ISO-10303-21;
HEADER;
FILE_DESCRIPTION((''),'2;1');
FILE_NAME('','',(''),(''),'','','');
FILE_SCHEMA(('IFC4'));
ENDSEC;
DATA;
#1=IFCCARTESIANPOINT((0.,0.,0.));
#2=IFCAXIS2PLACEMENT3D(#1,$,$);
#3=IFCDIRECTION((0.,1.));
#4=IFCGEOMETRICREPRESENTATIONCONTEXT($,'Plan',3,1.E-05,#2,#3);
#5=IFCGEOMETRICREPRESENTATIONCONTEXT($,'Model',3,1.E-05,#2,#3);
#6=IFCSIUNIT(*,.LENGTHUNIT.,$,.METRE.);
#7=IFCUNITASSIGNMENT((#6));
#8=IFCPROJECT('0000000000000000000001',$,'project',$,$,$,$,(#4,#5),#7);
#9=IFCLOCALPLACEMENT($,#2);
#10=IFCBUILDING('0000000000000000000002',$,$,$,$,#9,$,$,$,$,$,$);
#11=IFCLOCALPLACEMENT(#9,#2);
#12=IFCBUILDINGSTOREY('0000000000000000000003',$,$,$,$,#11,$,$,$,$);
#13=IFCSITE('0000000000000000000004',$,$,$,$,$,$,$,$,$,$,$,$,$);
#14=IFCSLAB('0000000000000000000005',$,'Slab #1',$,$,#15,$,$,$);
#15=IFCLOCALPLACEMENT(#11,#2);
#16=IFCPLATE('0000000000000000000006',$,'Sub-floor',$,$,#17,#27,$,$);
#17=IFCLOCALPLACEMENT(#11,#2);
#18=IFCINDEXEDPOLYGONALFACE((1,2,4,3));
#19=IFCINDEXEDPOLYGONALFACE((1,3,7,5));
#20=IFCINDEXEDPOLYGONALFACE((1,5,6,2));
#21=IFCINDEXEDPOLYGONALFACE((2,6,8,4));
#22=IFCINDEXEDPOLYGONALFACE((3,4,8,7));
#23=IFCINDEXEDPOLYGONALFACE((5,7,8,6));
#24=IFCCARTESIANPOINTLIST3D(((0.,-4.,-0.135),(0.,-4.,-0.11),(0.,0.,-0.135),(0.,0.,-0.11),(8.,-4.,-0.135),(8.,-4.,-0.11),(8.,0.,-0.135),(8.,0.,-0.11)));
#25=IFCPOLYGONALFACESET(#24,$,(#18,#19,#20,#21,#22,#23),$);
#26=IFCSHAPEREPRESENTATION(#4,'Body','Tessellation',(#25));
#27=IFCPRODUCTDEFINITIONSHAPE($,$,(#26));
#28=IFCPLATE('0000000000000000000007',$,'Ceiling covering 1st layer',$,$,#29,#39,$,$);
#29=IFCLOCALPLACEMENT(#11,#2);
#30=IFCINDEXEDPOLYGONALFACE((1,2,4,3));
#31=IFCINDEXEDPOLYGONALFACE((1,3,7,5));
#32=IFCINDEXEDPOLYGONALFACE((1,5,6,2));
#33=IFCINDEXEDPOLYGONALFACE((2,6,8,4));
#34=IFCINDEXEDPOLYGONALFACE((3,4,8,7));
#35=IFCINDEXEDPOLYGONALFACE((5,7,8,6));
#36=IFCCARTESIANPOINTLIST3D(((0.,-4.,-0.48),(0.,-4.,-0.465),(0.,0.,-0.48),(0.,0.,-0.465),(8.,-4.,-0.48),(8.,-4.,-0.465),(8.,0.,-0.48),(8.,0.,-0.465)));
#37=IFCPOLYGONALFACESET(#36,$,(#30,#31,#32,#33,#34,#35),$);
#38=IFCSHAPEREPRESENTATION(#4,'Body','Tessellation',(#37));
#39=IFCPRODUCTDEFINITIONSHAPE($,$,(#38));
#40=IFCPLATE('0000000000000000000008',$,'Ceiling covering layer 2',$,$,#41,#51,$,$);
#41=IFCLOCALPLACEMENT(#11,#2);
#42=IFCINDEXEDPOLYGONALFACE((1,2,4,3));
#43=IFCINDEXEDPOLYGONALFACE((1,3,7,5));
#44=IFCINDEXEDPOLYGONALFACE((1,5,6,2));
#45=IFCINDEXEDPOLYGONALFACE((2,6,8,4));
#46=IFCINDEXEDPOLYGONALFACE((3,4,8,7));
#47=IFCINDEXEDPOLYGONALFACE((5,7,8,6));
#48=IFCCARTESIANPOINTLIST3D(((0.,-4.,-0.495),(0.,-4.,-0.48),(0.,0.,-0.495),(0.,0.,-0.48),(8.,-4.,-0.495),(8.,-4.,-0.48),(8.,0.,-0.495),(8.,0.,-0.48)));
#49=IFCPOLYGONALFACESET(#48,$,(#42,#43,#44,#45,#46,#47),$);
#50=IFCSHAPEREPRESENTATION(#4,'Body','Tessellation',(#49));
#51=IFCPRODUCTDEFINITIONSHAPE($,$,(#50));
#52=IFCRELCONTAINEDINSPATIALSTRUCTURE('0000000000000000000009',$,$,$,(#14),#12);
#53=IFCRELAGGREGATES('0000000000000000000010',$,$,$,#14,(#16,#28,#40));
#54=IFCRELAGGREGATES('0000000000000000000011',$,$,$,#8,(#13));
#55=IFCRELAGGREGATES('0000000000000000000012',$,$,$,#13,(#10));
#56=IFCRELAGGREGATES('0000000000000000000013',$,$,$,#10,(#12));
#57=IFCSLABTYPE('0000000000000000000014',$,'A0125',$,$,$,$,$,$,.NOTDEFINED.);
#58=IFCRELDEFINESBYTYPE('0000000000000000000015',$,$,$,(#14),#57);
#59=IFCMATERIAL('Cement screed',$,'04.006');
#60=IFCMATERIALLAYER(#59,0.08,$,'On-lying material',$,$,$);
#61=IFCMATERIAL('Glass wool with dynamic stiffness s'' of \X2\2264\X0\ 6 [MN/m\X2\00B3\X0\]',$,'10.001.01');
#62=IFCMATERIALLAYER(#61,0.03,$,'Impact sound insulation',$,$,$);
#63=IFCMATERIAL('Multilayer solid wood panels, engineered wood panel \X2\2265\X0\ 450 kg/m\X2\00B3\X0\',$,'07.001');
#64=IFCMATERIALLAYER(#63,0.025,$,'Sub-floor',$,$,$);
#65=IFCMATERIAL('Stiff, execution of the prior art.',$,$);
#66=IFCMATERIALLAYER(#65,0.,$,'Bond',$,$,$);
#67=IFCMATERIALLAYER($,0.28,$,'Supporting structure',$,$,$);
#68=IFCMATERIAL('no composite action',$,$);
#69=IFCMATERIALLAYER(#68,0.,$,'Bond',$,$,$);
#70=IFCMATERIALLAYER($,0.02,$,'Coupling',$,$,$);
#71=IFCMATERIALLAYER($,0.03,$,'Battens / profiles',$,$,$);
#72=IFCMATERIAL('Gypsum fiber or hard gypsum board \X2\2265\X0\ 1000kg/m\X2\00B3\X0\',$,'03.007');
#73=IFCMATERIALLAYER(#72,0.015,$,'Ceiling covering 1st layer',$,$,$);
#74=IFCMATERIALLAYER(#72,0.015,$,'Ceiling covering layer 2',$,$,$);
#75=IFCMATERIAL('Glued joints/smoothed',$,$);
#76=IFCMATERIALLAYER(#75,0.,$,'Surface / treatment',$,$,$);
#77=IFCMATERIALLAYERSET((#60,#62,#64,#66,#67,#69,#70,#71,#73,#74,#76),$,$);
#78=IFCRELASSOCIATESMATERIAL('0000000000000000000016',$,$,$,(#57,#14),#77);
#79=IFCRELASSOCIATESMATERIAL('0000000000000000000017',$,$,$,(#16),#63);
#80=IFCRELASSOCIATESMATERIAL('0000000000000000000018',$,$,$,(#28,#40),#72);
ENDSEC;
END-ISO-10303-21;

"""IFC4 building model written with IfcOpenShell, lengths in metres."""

from ifc_helpers import new_model, si_unit, direction, frame, frame_2d, origin, place, context, project, spatial, rectangle, extrude, material, layer, layer_set, type_object, element, aggregate, save


model = new_model("IFC4")

# Units and contexts
plan_context = context("Plan", 3, precision=1e-05, world=origin(), true_north=direction((0.0, 1.0)))
model_context = context("Model", 3, precision=1e-05, world=origin(), true_north=direction((0.0, 1.0)))
ifc_project = project(units=[si_unit("LENGTHUNIT", "METRE")], contexts=[plan_context, model_context])

# Site, building, storey
site = spatial("IfcSite", under=ifc_project)
building_placement = place(None, origin())
building = spatial("IfcBuilding", under=site, at=building_placement)
storey_placement = place(building_placement, origin())
storey = spatial("IfcBuildingStorey", under=building, at=storey_placement)

# Slab, plates
ifc_material_1 = material(Name="Cement screed", Category="04.006")
ifc_layer_1 = layer(ifc_material_1, 0.08, Name="On-lying material")
ifc_material_2 = material(Name="Glass wool with dynamic stiffness s' of ≤ 6 [MN/m³]", Category="10.001.01")
ifc_layer_2 = layer(ifc_material_2, 0.03, Name="Impact sound insulation")
ifc_material_3 = material(Name="Multilayer solid wood panels, engineered wood panel ≥ 450 kg/m³", Category="07.001")
ifc_layer_3 = layer(ifc_material_3, 0.025, Name="Sub-floor")
ifc_material_4 = material(Name="Stiff, execution of the prior art.")
ifc_layer_4 = layer(ifc_material_4, 0.0, Name="Bond")
ifc_layer_5 = layer(None, 0.28, Name="Supporting structure")
ifc_material_5 = material(Name="no composite action")
ifc_layer_6 = layer(ifc_material_5, 0.0, Name="Bond")
ifc_layer_7 = layer(None, 0.02, Name="Coupling")
ifc_layer_8 = layer(None, 0.03, Name="Battens / profiles")
ifc_material_6 = material(Name="Gypsum fiber or hard gypsum board ≥ 1000kg/m³", Category="03.007")
ifc_layer_9 = layer(ifc_material_6, 0.015, Name="Ceiling covering 1st layer")
ifc_layer_10 = layer(ifc_material_6, 0.015, Name="Ceiling covering layer 2")
ifc_material_7 = material(Name="Glued joints/smoothed")
ifc_layer_11 = layer(ifc_material_7, 0.0, Name="Surface / treatment")
ifc_layer_set = layer_set([ifc_layer_1, ifc_layer_2, ifc_layer_3, ifc_layer_4, ifc_layer_5, ifc_layer_6, ifc_layer_7, ifc_layer_8, ifc_layer_9, ifc_layer_10, ifc_layer_11])
slab_type = type_object("IfcSlabType", Name="A0125", PredefinedType="NOTDEFINED", material=ifc_layer_set)
slab_placement = place(None, frame((0.0, 0.0, 0.0), z_axis=(0.0, 0.0, -1.0), x_axis=(1.0, 0.0, 0.0)))
slab = element("IfcSlab", 1, at=slab_placement, inside=storey, type_object=slab_type, material=ifc_layer_set, Name="Slab #1")
plate_1_placement = place(slab_placement, origin())
plate_1 = element("IfcPlate", 2, at=plate_1_placement, material=ifc_material_3, Name="Sub-floor", context=plan_context, shape_type="SweptSolid", body=[
    extrude(rectangle(XDim=8.0, YDim=4.0, at=frame_2d((4.0, 2.0), x_axis=(1.0, 0.0))), frame((0.0, 0.0, 0.11), z_axis=(0.0, 0.0, 1.0), x_axis=(1.0, 0.0, 0.0)), (0.0, 0.0, 1.0), 0.025),
])
plate_2_placement = place(slab_placement, origin())
plate_2 = element("IfcPlate", 3, at=plate_2_placement, material=ifc_material_6, Name="Ceiling covering 1st layer", context=plan_context, shape_type="SweptSolid", body=[
    extrude(rectangle(XDim=8.0, YDim=4.0, at=frame_2d((4.0, 2.0), x_axis=(1.0, 0.0))), frame((0.0, 0.0, 0.465), z_axis=(0.0, 0.0, 1.0), x_axis=(1.0, 0.0, 0.0)), (0.0, 0.0, 1.0), 0.015),
])
plate_3_placement = place(slab_placement, origin())
plate_3 = element("IfcPlate", 4, at=plate_3_placement, material=ifc_material_6, Name="Ceiling covering layer 2", context=plan_context, shape_type="SweptSolid", body=[
    extrude(rectangle(XDim=8.0, YDim=4.0, at=frame_2d((4.0, 2.0), x_axis=(1.0, 0.0))), frame((0.0, 0.0, 0.48), z_axis=(0.0, 0.0, 1.0), x_axis=(1.0, 0.0, 0.0)), (0.0, 0.0, 1.0), 0.015),
])
aggregate(slab, [plate_1, plate_2, plate_3])

save(model, "model.ifc")
